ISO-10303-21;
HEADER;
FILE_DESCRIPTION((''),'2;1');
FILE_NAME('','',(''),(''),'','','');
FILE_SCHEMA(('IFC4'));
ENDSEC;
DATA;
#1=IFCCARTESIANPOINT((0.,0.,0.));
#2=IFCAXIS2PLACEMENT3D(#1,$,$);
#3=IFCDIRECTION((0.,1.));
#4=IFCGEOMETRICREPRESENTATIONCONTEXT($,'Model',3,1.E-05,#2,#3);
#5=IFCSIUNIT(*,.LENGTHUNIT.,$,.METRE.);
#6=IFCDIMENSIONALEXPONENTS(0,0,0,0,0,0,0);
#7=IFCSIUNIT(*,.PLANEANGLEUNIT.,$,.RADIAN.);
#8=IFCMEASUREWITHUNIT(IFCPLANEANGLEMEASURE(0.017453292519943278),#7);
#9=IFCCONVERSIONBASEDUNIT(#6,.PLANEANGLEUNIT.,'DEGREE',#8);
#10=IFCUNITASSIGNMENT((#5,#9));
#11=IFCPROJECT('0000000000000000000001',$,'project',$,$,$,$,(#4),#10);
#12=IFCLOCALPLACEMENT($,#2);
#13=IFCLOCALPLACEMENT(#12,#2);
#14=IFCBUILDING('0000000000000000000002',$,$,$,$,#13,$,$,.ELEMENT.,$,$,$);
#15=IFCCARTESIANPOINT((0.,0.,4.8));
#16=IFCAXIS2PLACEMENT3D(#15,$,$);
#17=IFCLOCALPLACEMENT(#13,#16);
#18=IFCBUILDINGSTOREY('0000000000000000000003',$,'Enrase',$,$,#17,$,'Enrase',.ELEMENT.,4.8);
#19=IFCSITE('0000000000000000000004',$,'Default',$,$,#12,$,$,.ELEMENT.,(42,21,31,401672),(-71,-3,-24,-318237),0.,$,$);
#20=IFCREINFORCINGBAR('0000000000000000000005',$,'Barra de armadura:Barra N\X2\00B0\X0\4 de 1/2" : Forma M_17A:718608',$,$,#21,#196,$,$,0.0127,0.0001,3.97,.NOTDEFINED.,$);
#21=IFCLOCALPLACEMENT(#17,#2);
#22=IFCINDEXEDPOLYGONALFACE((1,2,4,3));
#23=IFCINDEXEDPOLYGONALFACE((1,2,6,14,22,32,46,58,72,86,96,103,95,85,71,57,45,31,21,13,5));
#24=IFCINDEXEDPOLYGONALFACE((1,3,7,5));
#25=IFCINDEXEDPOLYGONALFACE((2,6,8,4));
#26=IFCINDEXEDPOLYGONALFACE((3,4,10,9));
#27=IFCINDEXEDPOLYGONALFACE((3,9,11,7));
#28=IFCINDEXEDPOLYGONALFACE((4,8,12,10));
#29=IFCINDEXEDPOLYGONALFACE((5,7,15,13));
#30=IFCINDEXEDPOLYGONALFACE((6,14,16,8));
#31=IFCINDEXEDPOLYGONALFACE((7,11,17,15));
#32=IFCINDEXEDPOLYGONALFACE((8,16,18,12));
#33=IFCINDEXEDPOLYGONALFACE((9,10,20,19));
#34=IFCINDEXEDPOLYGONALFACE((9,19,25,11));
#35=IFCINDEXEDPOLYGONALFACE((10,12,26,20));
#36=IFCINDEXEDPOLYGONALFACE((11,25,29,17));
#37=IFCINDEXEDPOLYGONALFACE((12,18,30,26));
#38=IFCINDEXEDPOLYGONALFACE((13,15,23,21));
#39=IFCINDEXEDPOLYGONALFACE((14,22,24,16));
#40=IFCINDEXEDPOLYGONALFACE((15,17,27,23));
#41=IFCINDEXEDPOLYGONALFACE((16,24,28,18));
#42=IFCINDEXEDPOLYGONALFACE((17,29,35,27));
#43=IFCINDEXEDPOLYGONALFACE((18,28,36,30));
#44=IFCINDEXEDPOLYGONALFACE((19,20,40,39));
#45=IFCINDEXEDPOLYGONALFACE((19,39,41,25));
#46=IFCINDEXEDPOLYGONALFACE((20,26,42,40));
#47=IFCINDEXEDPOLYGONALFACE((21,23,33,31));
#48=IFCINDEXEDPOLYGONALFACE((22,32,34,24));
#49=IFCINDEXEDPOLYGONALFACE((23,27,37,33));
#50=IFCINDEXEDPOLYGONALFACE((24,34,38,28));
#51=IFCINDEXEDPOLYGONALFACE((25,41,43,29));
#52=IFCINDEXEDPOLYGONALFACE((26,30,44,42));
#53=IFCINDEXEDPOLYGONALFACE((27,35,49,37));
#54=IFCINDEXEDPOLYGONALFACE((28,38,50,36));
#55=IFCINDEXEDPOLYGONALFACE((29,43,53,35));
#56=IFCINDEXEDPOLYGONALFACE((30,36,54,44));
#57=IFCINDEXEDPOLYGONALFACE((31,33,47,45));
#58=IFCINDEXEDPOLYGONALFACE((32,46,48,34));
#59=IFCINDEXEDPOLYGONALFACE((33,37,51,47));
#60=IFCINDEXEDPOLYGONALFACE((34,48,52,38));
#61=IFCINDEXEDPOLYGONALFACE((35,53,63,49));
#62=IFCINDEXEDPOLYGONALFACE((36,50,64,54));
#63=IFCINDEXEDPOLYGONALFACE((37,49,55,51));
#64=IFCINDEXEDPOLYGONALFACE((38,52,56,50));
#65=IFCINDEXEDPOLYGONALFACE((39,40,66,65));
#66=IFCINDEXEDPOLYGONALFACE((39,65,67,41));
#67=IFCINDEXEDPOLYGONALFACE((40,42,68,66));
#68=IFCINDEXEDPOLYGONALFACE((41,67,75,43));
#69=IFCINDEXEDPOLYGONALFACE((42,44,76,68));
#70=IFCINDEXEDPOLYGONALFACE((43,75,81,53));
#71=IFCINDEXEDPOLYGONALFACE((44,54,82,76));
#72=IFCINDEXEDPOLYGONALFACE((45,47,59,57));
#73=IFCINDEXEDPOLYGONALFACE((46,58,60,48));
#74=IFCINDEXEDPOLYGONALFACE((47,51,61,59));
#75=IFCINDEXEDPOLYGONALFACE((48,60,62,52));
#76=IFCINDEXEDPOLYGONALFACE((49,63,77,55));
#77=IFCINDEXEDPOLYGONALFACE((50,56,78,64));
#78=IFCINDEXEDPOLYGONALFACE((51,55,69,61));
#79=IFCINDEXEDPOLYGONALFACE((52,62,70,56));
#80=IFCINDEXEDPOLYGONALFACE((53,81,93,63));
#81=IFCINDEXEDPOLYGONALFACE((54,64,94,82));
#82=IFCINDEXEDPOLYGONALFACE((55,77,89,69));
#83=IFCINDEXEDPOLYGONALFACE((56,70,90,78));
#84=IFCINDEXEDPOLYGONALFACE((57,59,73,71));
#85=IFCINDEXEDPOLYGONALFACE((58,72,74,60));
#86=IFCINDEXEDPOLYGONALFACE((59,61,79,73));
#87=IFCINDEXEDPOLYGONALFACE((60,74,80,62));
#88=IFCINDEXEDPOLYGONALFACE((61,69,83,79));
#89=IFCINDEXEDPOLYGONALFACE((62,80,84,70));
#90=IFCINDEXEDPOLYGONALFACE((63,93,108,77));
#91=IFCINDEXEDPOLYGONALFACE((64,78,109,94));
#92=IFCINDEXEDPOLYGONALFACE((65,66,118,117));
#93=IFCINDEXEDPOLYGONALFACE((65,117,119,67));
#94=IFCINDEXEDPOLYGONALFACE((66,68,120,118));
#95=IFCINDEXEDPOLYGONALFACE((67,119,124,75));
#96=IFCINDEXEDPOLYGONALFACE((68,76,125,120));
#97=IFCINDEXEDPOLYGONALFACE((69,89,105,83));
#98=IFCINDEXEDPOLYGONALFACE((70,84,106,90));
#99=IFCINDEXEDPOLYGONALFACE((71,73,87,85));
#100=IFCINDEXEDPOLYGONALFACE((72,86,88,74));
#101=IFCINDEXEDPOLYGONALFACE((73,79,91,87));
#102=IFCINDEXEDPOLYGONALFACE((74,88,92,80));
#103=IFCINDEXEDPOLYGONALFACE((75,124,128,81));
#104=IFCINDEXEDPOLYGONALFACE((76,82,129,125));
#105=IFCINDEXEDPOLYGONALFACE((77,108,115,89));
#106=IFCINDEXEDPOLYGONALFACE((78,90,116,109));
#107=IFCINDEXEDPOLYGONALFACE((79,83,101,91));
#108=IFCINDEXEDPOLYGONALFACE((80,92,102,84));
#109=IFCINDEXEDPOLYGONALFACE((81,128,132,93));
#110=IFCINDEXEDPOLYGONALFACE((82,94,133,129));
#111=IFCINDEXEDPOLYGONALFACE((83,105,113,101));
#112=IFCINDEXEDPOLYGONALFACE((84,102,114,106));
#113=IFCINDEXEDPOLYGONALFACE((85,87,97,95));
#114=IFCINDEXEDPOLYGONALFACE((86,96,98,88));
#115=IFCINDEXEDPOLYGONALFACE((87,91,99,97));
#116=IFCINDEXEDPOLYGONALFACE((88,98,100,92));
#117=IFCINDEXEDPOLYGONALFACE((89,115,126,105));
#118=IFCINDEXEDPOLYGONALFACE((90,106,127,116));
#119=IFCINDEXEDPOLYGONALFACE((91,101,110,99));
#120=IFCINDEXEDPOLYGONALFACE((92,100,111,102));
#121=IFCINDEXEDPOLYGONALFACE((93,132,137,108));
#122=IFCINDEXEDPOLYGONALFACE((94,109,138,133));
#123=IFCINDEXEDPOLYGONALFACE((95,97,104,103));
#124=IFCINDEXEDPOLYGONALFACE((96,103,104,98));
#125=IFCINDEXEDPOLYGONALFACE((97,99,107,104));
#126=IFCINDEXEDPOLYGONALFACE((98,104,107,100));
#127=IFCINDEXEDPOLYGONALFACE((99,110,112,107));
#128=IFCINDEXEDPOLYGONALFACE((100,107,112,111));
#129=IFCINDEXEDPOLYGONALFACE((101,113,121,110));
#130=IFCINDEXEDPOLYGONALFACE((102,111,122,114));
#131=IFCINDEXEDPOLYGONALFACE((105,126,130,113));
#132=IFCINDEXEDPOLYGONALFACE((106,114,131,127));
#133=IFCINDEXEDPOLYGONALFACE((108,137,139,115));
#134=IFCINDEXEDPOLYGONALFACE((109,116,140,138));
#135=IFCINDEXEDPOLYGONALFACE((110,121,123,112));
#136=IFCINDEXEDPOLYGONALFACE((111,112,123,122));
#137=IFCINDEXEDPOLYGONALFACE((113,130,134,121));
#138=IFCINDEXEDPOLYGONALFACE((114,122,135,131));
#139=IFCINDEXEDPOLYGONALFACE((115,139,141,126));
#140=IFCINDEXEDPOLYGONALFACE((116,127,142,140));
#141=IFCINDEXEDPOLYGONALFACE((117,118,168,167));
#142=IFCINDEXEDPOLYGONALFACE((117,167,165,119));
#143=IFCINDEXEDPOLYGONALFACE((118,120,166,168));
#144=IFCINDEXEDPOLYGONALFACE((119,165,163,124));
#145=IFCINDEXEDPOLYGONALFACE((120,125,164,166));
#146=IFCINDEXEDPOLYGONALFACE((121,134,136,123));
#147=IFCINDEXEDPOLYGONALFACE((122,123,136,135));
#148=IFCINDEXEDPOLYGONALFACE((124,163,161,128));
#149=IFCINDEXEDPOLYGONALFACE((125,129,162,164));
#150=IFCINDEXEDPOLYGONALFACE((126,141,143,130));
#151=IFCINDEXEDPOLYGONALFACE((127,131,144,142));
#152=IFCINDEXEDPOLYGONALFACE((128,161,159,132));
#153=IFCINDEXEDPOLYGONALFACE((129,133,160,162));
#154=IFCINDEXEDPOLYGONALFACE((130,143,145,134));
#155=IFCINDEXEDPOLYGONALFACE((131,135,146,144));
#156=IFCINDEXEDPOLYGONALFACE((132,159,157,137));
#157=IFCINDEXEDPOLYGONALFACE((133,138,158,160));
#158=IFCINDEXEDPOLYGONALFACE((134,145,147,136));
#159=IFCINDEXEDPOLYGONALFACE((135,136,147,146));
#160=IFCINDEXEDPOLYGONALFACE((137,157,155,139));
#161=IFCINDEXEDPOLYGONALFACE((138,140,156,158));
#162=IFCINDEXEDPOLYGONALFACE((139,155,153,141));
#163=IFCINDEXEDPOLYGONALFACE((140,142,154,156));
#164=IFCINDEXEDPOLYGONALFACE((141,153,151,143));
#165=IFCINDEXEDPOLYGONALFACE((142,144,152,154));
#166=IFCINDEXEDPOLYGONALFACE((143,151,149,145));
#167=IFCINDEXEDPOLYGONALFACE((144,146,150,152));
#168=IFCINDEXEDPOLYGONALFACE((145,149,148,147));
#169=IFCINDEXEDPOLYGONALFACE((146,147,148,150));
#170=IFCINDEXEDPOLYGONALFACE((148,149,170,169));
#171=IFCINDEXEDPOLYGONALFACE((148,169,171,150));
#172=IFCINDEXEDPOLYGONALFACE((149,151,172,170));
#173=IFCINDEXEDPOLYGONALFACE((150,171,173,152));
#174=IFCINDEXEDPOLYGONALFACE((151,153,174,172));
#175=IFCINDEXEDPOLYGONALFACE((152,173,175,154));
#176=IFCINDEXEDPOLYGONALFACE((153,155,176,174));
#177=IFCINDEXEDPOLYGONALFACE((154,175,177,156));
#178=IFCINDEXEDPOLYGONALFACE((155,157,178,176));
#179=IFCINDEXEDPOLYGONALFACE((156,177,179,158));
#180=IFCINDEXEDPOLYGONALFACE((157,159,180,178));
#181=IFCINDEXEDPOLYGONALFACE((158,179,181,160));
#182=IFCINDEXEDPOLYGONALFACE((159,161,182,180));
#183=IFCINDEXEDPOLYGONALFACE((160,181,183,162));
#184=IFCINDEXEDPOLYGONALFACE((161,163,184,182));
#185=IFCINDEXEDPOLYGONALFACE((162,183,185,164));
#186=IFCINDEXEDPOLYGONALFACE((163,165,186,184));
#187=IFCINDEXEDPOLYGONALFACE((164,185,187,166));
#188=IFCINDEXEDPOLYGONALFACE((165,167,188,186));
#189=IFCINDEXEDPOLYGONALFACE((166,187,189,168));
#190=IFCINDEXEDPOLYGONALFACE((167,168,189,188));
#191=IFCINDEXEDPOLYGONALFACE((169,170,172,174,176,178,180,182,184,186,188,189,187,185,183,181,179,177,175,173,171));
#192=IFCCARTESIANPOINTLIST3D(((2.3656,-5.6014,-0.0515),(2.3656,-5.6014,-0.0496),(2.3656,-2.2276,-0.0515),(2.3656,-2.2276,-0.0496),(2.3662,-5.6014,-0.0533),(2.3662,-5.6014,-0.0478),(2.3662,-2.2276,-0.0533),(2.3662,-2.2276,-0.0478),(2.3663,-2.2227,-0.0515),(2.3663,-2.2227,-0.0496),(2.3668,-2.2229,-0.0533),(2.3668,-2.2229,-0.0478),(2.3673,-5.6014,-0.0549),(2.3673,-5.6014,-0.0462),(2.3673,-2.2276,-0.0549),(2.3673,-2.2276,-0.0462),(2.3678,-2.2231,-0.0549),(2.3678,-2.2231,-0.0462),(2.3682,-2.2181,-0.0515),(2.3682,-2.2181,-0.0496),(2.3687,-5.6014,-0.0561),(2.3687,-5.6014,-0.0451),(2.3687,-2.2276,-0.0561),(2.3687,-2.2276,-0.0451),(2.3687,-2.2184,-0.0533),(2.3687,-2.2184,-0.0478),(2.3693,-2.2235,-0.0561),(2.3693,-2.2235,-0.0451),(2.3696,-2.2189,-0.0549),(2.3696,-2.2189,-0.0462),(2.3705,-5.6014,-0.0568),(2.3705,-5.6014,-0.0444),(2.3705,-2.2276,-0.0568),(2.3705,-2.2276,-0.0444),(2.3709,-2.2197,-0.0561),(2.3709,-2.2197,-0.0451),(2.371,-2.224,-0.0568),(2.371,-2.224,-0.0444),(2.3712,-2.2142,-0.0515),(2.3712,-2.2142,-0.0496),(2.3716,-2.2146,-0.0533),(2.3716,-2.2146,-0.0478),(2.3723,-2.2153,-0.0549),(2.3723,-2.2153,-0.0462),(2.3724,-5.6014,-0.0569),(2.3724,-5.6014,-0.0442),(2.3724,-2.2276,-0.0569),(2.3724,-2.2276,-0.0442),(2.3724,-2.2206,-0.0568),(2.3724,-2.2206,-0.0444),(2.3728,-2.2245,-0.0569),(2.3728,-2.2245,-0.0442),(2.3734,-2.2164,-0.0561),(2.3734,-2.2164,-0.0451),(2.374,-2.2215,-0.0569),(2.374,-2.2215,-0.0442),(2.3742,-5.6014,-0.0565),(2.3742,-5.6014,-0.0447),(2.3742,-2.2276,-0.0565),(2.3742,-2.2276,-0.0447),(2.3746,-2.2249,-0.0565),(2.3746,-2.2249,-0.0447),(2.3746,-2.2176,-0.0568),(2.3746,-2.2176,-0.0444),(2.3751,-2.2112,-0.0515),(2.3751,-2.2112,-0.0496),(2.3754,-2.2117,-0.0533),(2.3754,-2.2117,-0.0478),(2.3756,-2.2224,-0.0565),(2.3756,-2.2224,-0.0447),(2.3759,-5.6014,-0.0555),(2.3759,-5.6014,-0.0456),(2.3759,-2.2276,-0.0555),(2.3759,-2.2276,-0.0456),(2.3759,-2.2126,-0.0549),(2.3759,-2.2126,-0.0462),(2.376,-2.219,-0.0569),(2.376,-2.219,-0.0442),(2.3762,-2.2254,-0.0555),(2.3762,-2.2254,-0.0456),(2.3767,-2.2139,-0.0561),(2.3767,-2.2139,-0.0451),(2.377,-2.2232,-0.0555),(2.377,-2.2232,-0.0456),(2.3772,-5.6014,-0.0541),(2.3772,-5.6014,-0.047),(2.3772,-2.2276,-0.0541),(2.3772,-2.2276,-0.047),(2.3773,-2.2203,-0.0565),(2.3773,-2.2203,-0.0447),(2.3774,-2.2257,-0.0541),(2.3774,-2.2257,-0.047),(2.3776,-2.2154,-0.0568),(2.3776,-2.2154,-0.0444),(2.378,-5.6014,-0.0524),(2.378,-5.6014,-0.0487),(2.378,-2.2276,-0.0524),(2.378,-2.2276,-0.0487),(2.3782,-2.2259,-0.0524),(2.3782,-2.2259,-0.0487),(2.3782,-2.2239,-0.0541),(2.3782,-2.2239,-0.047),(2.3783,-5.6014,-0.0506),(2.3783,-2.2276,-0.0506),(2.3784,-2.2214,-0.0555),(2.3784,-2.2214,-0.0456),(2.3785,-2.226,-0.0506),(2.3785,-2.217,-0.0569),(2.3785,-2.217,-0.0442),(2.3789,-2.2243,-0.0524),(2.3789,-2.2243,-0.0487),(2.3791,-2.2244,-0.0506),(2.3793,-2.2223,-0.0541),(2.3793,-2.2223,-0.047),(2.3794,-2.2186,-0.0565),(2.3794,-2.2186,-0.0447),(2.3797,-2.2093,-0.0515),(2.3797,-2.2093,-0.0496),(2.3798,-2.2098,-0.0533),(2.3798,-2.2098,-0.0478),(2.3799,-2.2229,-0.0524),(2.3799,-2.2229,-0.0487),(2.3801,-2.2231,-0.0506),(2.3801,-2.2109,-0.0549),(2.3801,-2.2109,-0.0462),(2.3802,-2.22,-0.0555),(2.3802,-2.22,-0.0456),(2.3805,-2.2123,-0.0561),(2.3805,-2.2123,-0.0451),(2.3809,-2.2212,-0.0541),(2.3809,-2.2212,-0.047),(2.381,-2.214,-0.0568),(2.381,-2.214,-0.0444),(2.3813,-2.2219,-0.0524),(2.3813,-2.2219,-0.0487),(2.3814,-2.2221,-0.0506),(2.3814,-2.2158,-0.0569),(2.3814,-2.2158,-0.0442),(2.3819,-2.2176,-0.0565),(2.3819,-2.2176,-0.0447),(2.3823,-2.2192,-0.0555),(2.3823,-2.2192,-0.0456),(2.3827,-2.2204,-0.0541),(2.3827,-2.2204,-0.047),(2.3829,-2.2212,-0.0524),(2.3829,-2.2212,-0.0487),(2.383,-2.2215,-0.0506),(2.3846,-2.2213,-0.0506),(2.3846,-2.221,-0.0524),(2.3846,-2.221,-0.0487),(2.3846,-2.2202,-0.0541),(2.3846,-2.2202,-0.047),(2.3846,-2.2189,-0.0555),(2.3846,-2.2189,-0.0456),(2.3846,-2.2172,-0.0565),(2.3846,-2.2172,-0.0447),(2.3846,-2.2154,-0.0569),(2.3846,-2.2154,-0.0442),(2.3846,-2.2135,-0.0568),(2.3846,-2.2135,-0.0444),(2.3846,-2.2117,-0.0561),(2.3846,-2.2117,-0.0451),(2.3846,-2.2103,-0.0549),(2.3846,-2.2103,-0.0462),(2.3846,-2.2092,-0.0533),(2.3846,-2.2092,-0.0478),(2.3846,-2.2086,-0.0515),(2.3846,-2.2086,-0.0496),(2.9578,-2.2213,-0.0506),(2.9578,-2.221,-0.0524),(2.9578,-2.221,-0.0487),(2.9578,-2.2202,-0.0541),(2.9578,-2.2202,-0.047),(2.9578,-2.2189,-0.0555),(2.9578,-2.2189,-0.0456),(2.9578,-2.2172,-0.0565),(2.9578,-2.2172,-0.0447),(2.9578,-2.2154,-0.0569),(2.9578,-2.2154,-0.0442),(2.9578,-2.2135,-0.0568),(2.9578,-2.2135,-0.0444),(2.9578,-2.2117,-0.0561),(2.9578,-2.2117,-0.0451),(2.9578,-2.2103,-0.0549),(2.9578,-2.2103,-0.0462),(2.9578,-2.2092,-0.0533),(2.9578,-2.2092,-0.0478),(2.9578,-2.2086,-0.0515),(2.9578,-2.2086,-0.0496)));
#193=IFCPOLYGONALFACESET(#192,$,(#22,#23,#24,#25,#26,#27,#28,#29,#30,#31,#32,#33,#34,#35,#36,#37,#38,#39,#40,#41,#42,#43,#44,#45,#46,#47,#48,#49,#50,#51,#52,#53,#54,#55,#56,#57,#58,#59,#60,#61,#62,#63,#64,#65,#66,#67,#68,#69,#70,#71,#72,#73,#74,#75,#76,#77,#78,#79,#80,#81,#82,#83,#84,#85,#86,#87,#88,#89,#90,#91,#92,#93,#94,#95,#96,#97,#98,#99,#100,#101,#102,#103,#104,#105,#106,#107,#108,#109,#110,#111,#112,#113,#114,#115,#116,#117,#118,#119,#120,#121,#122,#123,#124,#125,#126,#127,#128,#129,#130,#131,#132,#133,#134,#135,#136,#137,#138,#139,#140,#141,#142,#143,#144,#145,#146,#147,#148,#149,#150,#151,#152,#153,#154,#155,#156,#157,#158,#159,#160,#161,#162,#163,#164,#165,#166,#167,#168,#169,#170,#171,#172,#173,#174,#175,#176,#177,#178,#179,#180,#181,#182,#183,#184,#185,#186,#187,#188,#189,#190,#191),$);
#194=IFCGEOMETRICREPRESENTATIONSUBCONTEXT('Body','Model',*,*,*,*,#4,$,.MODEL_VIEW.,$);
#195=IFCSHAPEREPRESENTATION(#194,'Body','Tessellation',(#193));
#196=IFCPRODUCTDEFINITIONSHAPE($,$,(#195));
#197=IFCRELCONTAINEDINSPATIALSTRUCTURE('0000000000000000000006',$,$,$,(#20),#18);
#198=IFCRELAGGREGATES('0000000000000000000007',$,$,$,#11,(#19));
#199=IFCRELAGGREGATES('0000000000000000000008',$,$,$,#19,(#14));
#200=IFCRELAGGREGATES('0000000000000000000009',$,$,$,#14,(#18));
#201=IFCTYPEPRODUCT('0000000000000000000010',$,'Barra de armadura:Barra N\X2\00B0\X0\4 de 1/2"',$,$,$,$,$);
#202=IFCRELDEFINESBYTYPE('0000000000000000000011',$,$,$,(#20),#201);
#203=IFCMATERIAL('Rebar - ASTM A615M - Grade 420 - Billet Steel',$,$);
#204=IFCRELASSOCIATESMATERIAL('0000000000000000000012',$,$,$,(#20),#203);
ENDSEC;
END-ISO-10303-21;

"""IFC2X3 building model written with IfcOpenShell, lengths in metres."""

from ifc_helpers import new_model, entity, si_unit, converted_unit, direction, frame, origin, place, context, subcontext, project, spatial, material, type_object, element, save


model = new_model("IFC2X3")

# Units and contexts
model_context = context("Model", 3, precision=1e-05, world=origin(), true_north=direction((0.0, 1.0)))
body_context = subcontext(model_context, "Body", "Model", "MODEL_VIEW")
ifc_project = project(units=[si_unit("LENGTHUNIT", "METRE"), converted_unit("PLANEANGLEUNIT", "DEGREE", entity("IfcPlaneAngleMeasure", 0.017453292519943278), si_unit("PLANEANGLEUNIT", "RADIAN"), dimensions=[0, 0, 0, 0, 0, 0, 0])], contexts=[model_context])

# Site, building, storey
site_placement = place(None, origin())
site = spatial("IfcSite", under=ifc_project, at=site_placement, Name="Default", CompositionType="ELEMENT", RefLatitude=(42, 21, 31, 401672), RefLongitude=(-71, -3, -24, -318237), RefElevation=0.0)
building_placement = place(site_placement, origin())
building = spatial("IfcBuilding", under=site, at=building_placement, CompositionType="ELEMENT")
storey_placement = place(building_placement, frame((0.0, 0.0, 4.8)))
storey = spatial("IfcBuildingStorey", under=building, at=storey_placement, Name="Enrase", LongName="Enrase", CompositionType="ELEMENT", Elevation=4.8)

# Reinforcing bar
ifc_material = material(Name="Rebar - ASTM A615M - Grade 420 - Billet Steel")
type_product_1 = type_object("IfcTypeProduct", Name="Barra de armadura:Barra N°4 de 1/2\"")
reinforcing_bar_1_placement = place(storey_placement, origin())
element("IfcReinforcingBar", 1, at=reinforcing_bar_1_placement, inside=storey, type_object=type_product_1, material=ifc_material, Name="Barra de armadura:Barra N°4 de 1/2\" : Forma M_17A:718608", BarLength=3.97, BarRole="NOTDEFINED", CrossSectionArea=0.0001, NominalDiameter=0.0127, context=body_context, shape_type="AdvancedSweptSolid", body=[
    entity("IfcSweptDiskSolid", entity("IfcCompositeCurve", [entity("IfcCompositeCurveSegment", "CONTINUOUS", True, entity("IfcPolyline", [entity("IfcCartesianPoint", [2.3719, -5.6014, -0.0506]), entity("IfcCartesianPoint", [2.3719, -2.2276, -0.0506])])), entity("IfcCompositeCurveSegment", "CONTINUOUS", True, entity("IfcTrimmedCurve", entity("IfcCircle", entity("IfcAxis2Placement3D", entity("IfcCartesianPoint", [2.3846, -2.2276, -0.0506]), entity("IfcDirection", [0.0, 0.0, -1.0]), entity("IfcDirection", [0.0, 1.0, 0.0])), 0.0127), [entity("IfcParameterValue", 270.0)], [entity("IfcParameterValue", 360.0)], True, "PARAMETER")), entity("IfcCompositeCurveSegment", "CONTINUOUS", True, entity("IfcPolyline", [entity("IfcCartesianPoint", [2.3846, -2.2149, -0.0506]), entity("IfcCartesianPoint", [2.9578, -2.2149, -0.0506])]))], False), 0.0063, None, 0.0, 92.0),
])

save(model, "model.ifc")
